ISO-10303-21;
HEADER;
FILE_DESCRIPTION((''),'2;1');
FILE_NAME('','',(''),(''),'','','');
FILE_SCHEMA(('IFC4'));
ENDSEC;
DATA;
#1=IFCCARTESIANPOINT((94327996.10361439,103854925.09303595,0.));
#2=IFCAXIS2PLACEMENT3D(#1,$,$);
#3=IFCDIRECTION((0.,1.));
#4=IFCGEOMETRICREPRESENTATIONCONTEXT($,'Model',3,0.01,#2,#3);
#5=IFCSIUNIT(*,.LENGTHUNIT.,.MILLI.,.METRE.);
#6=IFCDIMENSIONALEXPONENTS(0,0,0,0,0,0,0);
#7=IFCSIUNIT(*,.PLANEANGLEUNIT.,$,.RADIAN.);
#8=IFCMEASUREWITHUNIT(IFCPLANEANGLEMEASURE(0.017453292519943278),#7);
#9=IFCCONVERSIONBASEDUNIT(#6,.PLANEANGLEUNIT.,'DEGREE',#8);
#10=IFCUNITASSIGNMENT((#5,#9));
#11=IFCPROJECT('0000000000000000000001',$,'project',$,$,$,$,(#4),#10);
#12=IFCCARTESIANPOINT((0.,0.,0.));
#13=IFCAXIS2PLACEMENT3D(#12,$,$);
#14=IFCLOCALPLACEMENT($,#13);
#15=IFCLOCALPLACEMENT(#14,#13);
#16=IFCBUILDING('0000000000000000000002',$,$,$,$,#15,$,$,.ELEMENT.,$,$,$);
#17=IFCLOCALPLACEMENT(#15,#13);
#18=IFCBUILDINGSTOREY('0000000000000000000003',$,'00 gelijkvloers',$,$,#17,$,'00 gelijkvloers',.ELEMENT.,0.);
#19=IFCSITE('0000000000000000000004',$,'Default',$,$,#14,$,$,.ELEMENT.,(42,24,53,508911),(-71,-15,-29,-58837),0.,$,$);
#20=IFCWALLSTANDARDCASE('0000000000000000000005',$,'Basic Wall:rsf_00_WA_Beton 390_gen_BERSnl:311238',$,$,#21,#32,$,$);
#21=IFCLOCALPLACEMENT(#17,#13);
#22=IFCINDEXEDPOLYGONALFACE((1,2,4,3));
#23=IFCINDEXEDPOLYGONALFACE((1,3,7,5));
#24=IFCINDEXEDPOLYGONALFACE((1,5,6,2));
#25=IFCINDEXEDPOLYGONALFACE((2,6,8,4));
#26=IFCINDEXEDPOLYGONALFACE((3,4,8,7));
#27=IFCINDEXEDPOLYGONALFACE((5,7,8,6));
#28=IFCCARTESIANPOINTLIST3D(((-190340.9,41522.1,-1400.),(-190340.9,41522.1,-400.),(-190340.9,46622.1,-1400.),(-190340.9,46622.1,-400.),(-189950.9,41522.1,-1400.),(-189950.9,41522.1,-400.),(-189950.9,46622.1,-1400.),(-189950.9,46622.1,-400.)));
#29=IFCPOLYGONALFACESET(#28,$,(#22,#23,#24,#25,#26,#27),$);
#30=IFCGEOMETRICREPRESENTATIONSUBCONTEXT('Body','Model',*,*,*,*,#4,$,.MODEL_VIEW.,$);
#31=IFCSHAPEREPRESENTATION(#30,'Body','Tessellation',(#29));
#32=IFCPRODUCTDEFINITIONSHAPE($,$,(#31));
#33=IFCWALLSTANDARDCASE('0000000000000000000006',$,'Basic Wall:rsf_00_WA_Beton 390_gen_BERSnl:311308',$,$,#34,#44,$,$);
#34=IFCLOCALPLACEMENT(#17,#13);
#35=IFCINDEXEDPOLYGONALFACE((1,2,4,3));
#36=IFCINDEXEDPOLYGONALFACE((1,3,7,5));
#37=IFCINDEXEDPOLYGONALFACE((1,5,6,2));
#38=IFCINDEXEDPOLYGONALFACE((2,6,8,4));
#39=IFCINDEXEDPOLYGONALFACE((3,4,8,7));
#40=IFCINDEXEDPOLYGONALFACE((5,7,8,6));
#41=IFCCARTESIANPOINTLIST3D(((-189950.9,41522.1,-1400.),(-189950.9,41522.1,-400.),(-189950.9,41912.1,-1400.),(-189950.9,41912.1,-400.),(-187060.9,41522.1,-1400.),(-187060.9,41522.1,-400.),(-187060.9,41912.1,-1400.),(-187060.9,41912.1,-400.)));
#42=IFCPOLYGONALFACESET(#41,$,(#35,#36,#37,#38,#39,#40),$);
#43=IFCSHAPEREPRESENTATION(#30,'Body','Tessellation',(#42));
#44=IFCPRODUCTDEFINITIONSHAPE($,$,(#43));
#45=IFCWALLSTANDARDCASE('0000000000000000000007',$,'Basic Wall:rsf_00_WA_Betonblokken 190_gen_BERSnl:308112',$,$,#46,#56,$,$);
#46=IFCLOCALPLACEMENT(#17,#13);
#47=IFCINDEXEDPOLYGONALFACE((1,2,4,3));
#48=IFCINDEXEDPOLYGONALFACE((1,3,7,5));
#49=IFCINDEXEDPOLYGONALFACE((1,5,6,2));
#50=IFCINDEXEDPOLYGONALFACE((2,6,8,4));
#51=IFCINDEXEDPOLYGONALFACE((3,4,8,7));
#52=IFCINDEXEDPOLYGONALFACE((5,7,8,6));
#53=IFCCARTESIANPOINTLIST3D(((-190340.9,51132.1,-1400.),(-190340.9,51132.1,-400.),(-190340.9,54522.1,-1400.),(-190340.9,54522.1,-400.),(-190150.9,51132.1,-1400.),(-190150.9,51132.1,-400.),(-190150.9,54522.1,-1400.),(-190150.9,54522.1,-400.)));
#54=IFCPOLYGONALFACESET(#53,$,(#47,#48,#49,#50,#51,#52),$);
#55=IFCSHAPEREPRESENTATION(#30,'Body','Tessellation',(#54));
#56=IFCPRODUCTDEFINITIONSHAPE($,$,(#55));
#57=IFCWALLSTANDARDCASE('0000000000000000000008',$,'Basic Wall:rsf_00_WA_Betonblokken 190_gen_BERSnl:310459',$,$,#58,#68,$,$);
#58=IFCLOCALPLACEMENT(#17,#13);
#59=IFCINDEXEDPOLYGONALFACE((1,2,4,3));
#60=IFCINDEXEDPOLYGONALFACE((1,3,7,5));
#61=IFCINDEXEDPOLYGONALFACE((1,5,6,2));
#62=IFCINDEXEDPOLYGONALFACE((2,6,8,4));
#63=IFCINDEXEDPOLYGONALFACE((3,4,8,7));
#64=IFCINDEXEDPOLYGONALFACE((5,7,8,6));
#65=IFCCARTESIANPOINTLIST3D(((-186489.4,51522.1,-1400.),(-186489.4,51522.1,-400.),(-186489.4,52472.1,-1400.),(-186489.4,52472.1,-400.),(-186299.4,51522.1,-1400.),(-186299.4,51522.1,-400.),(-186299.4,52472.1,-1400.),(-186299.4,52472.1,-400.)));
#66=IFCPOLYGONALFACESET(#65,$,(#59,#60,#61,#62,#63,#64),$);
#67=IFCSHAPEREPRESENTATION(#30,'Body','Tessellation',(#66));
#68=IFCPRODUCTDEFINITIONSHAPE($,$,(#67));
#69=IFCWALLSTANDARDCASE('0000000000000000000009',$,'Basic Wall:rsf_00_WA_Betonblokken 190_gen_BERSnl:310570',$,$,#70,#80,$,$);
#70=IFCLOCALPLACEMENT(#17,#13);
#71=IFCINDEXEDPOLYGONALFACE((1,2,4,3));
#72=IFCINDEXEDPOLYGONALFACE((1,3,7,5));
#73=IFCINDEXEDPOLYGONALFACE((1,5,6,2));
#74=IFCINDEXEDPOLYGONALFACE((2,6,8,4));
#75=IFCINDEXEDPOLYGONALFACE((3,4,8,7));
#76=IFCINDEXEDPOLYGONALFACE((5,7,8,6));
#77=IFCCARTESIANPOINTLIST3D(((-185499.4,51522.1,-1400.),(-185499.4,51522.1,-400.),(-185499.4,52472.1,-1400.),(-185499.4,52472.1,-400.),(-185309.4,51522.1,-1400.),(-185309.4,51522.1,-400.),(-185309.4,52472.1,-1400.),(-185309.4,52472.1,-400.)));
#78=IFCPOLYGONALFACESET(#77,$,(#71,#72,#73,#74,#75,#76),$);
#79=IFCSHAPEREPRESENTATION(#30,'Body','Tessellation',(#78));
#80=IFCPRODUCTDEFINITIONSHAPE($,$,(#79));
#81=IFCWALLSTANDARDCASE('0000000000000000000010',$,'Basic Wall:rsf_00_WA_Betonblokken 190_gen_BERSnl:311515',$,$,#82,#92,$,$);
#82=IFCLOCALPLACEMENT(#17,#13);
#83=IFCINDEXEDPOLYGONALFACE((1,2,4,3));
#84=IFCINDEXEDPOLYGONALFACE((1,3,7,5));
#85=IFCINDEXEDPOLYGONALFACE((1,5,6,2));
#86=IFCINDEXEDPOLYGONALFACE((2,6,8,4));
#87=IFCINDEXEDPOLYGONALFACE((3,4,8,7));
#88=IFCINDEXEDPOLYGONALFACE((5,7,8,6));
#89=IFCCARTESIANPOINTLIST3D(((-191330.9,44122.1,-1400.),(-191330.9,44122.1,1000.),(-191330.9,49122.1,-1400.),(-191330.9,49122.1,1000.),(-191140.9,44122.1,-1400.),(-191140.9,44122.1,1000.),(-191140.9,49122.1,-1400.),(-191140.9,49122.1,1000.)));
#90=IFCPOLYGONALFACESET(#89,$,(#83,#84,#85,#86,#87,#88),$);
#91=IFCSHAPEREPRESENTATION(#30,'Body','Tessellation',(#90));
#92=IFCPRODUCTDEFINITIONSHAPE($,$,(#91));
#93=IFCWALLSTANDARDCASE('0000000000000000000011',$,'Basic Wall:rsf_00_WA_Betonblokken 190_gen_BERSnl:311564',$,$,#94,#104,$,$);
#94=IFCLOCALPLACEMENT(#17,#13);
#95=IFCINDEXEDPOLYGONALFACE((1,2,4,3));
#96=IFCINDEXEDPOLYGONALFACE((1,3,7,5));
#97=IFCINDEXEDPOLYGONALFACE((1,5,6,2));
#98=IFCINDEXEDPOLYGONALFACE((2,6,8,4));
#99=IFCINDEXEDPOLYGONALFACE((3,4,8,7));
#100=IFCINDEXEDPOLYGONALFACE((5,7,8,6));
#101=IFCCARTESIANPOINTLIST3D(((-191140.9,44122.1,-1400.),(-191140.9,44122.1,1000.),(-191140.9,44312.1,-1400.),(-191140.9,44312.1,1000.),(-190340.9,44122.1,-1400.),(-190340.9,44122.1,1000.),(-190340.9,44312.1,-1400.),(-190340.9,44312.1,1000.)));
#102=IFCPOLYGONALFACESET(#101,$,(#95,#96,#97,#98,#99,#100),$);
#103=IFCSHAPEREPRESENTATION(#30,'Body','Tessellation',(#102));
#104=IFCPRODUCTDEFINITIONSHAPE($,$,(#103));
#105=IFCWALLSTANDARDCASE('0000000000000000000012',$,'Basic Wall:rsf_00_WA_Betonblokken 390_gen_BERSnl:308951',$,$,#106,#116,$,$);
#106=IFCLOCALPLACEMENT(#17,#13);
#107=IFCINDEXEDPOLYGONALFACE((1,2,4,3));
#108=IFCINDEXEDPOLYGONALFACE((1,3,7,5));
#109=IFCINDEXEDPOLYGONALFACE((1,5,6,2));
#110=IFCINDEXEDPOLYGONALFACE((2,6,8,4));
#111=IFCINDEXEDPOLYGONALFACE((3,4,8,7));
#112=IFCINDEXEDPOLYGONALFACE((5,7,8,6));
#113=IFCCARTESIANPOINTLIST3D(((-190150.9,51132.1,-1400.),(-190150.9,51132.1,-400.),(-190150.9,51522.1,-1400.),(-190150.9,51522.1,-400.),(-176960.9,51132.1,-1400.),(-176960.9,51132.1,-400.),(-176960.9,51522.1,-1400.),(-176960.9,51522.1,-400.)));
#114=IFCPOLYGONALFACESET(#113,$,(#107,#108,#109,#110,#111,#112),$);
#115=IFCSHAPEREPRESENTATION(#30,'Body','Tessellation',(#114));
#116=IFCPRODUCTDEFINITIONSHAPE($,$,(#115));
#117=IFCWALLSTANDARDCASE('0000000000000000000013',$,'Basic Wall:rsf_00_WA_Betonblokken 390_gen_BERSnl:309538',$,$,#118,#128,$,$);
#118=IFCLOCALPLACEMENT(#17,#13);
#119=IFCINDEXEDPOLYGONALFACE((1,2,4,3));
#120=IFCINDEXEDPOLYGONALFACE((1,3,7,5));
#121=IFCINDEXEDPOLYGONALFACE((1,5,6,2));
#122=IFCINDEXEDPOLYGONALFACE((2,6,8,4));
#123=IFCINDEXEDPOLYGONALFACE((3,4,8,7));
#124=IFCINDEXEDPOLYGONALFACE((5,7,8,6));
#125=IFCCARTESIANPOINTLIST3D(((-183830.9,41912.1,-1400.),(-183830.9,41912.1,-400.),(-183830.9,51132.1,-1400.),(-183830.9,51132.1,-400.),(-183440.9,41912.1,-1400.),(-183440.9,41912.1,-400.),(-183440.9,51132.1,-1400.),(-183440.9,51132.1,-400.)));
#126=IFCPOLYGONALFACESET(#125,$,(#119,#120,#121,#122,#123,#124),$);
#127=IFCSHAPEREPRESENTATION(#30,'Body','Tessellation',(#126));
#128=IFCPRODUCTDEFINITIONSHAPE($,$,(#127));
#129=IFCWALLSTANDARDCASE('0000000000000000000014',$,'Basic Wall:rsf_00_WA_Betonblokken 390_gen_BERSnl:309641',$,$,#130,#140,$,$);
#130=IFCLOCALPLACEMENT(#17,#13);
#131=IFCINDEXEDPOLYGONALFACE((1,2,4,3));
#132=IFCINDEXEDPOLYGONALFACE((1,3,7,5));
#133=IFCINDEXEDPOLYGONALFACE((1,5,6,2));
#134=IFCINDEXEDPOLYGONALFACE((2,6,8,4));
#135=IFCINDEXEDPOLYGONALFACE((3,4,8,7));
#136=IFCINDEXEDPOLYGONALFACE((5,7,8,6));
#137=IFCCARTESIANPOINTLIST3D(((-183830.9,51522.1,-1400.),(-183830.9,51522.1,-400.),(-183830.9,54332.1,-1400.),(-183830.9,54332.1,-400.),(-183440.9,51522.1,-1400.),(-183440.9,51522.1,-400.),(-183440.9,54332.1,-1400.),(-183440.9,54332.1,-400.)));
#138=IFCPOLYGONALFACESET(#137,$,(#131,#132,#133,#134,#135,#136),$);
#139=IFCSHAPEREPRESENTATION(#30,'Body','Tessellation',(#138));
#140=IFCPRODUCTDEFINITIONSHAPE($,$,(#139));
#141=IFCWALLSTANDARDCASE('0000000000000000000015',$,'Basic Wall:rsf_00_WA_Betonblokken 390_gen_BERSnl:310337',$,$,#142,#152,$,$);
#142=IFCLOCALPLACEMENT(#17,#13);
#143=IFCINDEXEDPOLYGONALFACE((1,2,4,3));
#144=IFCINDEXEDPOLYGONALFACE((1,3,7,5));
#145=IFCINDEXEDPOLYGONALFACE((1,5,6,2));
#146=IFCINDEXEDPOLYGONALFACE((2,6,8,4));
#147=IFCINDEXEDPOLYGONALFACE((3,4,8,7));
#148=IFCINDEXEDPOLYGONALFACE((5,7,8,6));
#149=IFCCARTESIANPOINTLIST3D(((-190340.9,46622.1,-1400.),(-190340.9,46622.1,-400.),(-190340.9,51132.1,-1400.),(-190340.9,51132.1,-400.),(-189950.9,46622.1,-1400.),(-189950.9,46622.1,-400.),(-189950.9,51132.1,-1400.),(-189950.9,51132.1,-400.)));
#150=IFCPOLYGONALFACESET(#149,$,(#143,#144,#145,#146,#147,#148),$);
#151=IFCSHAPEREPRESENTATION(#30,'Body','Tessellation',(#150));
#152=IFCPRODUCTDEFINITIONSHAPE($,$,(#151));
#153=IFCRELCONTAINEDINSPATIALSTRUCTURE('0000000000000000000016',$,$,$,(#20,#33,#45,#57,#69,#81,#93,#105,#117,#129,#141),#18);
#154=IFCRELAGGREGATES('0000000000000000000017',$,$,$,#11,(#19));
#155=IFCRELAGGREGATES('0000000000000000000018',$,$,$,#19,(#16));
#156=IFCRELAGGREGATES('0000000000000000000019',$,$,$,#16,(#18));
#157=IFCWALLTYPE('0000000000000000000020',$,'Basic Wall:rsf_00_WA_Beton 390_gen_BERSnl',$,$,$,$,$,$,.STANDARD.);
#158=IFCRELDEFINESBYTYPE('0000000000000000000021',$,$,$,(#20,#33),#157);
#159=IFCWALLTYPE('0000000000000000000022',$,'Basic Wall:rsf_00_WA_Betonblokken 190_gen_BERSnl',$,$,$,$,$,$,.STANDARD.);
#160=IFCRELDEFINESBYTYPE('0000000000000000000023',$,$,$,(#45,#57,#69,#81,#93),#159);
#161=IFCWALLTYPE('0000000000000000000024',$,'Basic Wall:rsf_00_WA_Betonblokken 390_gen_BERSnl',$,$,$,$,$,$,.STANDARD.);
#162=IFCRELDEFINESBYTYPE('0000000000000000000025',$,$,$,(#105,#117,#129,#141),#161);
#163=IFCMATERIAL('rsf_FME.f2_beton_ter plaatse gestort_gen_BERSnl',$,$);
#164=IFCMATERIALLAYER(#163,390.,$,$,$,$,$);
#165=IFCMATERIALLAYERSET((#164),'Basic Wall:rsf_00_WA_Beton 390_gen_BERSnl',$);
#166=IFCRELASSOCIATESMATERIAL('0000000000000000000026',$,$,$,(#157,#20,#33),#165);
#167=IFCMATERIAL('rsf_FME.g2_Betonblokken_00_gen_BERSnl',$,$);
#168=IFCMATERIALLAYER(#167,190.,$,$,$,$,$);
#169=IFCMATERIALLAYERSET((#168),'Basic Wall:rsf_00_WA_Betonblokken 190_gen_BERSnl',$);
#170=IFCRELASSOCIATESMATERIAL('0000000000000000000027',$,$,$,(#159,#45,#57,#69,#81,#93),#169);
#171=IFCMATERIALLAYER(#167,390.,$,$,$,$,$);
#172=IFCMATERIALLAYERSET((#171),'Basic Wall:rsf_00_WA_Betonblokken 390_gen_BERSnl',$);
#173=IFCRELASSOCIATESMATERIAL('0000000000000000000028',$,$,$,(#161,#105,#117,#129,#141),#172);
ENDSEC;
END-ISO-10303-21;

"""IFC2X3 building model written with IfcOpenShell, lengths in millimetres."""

from ifc_helpers import new_model, entity, si_unit, converted_unit, direction, frame, frame_2d, origin, place, context, subcontext, project, spatial, rectangle, extrude, material, layer, layer_set, layer_usage, type_object, element, save


model = new_model("IFC2X3")

# Units and contexts
model_context = context("Model", 3, precision=0.01, world=frame((94327996.10361439, 103854925.09303595, 0.0)), true_north=direction((0.0, 1.0)))
body_context = subcontext(model_context, "Body", "Model", "MODEL_VIEW")
ifc_project = project(units=[si_unit("LENGTHUNIT", "METRE", prefix="MILLI"), converted_unit("PLANEANGLEUNIT", "DEGREE", entity("IfcPlaneAngleMeasure", 0.017453292519943278), si_unit("PLANEANGLEUNIT", "RADIAN"), dimensions=[0, 0, 0, 0, 0, 0, 0])], contexts=[model_context])

# Site, building, storey
site_placement = place(None, origin())
site = spatial("IfcSite", under=ifc_project, at=site_placement, Name="Default", CompositionType="ELEMENT", RefLatitude=(42, 24, 53, 508911), RefLongitude=(-71, -15, -29, -58837), RefElevation=0.0)
building_placement = place(site_placement, origin())
building = spatial("IfcBuilding", under=site, at=building_placement, CompositionType="ELEMENT")
storey_placement = place(building_placement, origin())
storey = spatial("IfcBuildingStorey", under=building, at=storey_placement, Name="00 gelijkvloers", LongName="00 gelijkvloers", CompositionType="ELEMENT", Elevation=0.0)

# Walls
ifc_material_1 = material(Name="rsf_FME.f2_beton_ter plaatse gestort_gen_BERSnl")
ifc_layer_1 = layer(ifc_material_1, 390.0)
ifc_layer_set_1 = layer_set([ifc_layer_1], Name="Basic Wall:rsf_00_WA_Beton 390_gen_BERSnl")
ifc_layer_usage_1 = layer_usage(ifc_layer_set_1, "AXIS2", "POSITIVE", -195.0)
wall_type_1 = type_object("IfcWallType", Name="Basic Wall:rsf_00_WA_Beton 390_gen_BERSnl", PredefinedType="STANDARD", material=ifc_layer_set_1)
wall_1_placement = place(storey_placement, frame((-190145.9, 46622.1, -1400.0), z_axis=(0.0, 0.0, 1.0), x_axis=(0.0, -1.0, 0.0)))
element("IfcWallStandardCase", 1, at=wall_1_placement, inside=storey, type_object=wall_type_1, material=ifc_layer_usage_1, Name="Basic Wall:rsf_00_WA_Beton 390_gen_BERSnl:311238", context=body_context, shape_type="SweptSolid", body=[
    extrude(rectangle(XDim=5100.0, YDim=390.0, at=frame_2d((2550.0, 0.0), x_axis=(-1.0, 0.0))), origin(), (0.0, 0.0, 1.0), 1000.0),
])
ifc_layer_usage_2 = layer_usage(ifc_layer_set_1, "AXIS2", "POSITIVE", -195.0)
wall_2_placement = place(storey_placement, frame((-189950.9, 41717.1, -1400.0)))
element("IfcWallStandardCase", 2, at=wall_2_placement, inside=storey, type_object=wall_type_1, material=ifc_layer_usage_2, Name="Basic Wall:rsf_00_WA_Beton 390_gen_BERSnl:311308", context=body_context, shape_type="SweptSolid", body=[
    extrude(rectangle(XDim=2890.0, YDim=390.0, at=frame_2d((1445.0, 0.0), x_axis=(-1.0, 0.0))), origin(), (0.0, 0.0, 1.0), 1000.0),
])
ifc_material_2 = material(Name="rsf_FME.g2_Betonblokken_00_gen_BERSnl")
ifc_layer_2 = layer(ifc_material_2, 190.0)
ifc_layer_set_2 = layer_set([ifc_layer_2], Name="Basic Wall:rsf_00_WA_Betonblokken 190_gen_BERSnl")
ifc_layer_usage_3 = layer_usage(ifc_layer_set_2, "AXIS2", "NEGATIVE", 95.0)
wall_type_2 = type_object("IfcWallType", Name="Basic Wall:rsf_00_WA_Betonblokken 190_gen_BERSnl", PredefinedType="STANDARD", material=ifc_layer_set_2)
wall_3_placement = place(storey_placement, frame((-190245.9, 51132.1, -1400.0), z_axis=(0.0, 0.0, 1.0), x_axis=(0.0, 1.0, 0.0)))
element("IfcWallStandardCase", 3, at=wall_3_placement, inside=storey, type_object=wall_type_2, material=ifc_layer_usage_3, Name="Basic Wall:rsf_00_WA_Betonblokken 190_gen_BERSnl:308112", context=body_context, shape_type="SweptSolid", body=[
    extrude(rectangle(XDim=3390.0, YDim=190.0, at=frame_2d((1695.0, 0.0), x_axis=(-1.0, 0.0))), origin(), (0.0, 0.0, 1.0), 1000.0),
])
ifc_layer_usage_4 = layer_usage(ifc_layer_set_2, "AXIS2", "POSITIVE", -95.0)
wall_4_placement = place(storey_placement, frame((-186394.4, 51522.1, -1400.0), z_axis=(0.0, 0.0, 1.0), x_axis=(0.0, 1.0, 0.0)))
element("IfcWallStandardCase", 4, at=wall_4_placement, inside=storey, type_object=wall_type_2, material=ifc_layer_usage_4, Name="Basic Wall:rsf_00_WA_Betonblokken 190_gen_BERSnl:310459", context=body_context, shape_type="SweptSolid", body=[
    extrude(rectangle(XDim=950.0, YDim=190.0, at=frame_2d((475.0, 0.0), x_axis=(-1.0, 0.0))), origin(), (0.0, 0.0, 1.0), 1000.0),
])
ifc_layer_usage_5 = layer_usage(ifc_layer_set_2, "AXIS2", "NEGATIVE", 95.0)
wall_5_placement = place(storey_placement, frame((-185404.4, 51522.1, -1400.0), z_axis=(0.0, 0.0, 1.0), x_axis=(0.0, 1.0, 0.0)))
element("IfcWallStandardCase", 5, at=wall_5_placement, inside=storey, type_object=wall_type_2, material=ifc_layer_usage_5, Name="Basic Wall:rsf_00_WA_Betonblokken 190_gen_BERSnl:310570", context=body_context, shape_type="SweptSolid", body=[
    extrude(rectangle(XDim=950.0, YDim=190.0, at=frame_2d((475.0, 0.0), x_axis=(-1.0, 0.0))), origin(), (0.0, 0.0, 1.0), 1000.0),
])
ifc_layer_usage_6 = layer_usage(ifc_layer_set_2, "AXIS2", "NEGATIVE", 95.0)
wall_6_placement = place(storey_placement, frame((-191235.9, 49122.1, -1400.0), z_axis=(0.0, 0.0, 1.0), x_axis=(0.0, -1.0, 0.0)))
element("IfcWallStandardCase", 6, at=wall_6_placement, inside=storey, type_object=wall_type_2, material=ifc_layer_usage_6, Name="Basic Wall:rsf_00_WA_Betonblokken 190_gen_BERSnl:311515", context=body_context, shape_type="SweptSolid", body=[
    extrude(rectangle(XDim=5000.0, YDim=190.0, at=frame_2d((2500.0, 0.0), x_axis=(-1.0, 0.0))), origin(), (0.0, 0.0, 1.0), 2400.0),
])
ifc_layer_usage_7 = layer_usage(ifc_layer_set_2, "AXIS2", "NEGATIVE", 95.0)
wall_7_placement = place(storey_placement, frame((-191140.9, 44217.1, -1400.0)))
element("IfcWallStandardCase", 7, at=wall_7_placement, inside=storey, type_object=wall_type_2, material=ifc_layer_usage_7, Name="Basic Wall:rsf_00_WA_Betonblokken 190_gen_BERSnl:311564", context=body_context, shape_type="SweptSolid", body=[
    extrude(rectangle(XDim=800.0, YDim=190.0, at=frame_2d((400.0, 0.0), x_axis=(-1.0, 0.0))), origin(), (0.0, 0.0, 1.0), 2400.0),
])
ifc_layer_3 = layer(ifc_material_2, 390.0)
ifc_layer_set_3 = layer_set([ifc_layer_3], Name="Basic Wall:rsf_00_WA_Betonblokken 390_gen_BERSnl")
ifc_layer_usage_8 = layer_usage(ifc_layer_set_3, "AXIS2", "NEGATIVE", 195.0)
wall_type_3 = type_object("IfcWallType", Name="Basic Wall:rsf_00_WA_Betonblokken 390_gen_BERSnl", PredefinedType="STANDARD", material=ifc_layer_set_3)
wall_8_placement = place(storey_placement, frame((-190150.9, 51327.1, -1400.0)))
element("IfcWallStandardCase", 8, at=wall_8_placement, inside=storey, type_object=wall_type_3, material=ifc_layer_usage_8, Name="Basic Wall:rsf_00_WA_Betonblokken 390_gen_BERSnl:308951", context=body_context, shape_type="SweptSolid", body=[
    extrude(rectangle(XDim=13190.0, YDim=390.0, at=frame_2d((6595.0, 0.0), x_axis=(-1.0, 0.0))), origin(), (0.0, 0.0, 1.0), 1000.0),
])
ifc_layer_usage_9 = layer_usage(ifc_layer_set_3, "AXIS2", "NEGATIVE", 195.0)
wall_9_placement = place(storey_placement, frame((-183635.9, 41912.1, -1400.0), z_axis=(0.0, 0.0, 1.0), x_axis=(0.0, 1.0, 0.0)))
element("IfcWallStandardCase", 9, at=wall_9_placement, inside=storey, type_object=wall_type_3, material=ifc_layer_usage_9, Name="Basic Wall:rsf_00_WA_Betonblokken 390_gen_BERSnl:309538", context=body_context, shape_type="SweptSolid", body=[
    extrude(rectangle(XDim=9220.0, YDim=390.0, at=frame_2d((4610.0, 0.0), x_axis=(-1.0, 0.0))), origin(), (0.0, 0.0, 1.0), 1000.0),
])
ifc_layer_usage_10 = layer_usage(ifc_layer_set_3, "AXIS2", "POSITIVE", -195.0)
wall_10_placement = place(storey_placement, frame((-183635.9, 51522.1, -1400.0), z_axis=(0.0, 0.0, 1.0), x_axis=(0.0, 1.0, 0.0)))
element("IfcWallStandardCase", 10, at=wall_10_placement, inside=storey, type_object=wall_type_3, material=ifc_layer_usage_10, Name="Basic Wall:rsf_00_WA_Betonblokken 390_gen_BERSnl:309641", context=body_context, shape_type="SweptSolid", body=[
    extrude(rectangle(XDim=2810.0, YDim=390.0, at=frame_2d((1405.0, 0.0), x_axis=(-1.0, 0.0))), origin(), (0.0, 0.0, 1.0), 1000.0),
])
ifc_layer_usage_11 = layer_usage(ifc_layer_set_3, "AXIS2", "NEGATIVE", 195.0)
wall_11_placement = place(storey_placement, frame((-190145.9, 51132.1, -1400.0), z_axis=(0.0, 0.0, 1.0), x_axis=(0.0, -1.0, 0.0)))
element("IfcWallStandardCase", 11, at=wall_11_placement, inside=storey, type_object=wall_type_3, material=ifc_layer_usage_11, Name="Basic Wall:rsf_00_WA_Betonblokken 390_gen_BERSnl:310337", context=body_context, shape_type="SweptSolid", body=[
    extrude(rectangle(XDim=4510.0, YDim=390.0, at=frame_2d((2255.0, 0.0), x_axis=(-1.0, 0.0))), origin(), (0.0, 0.0, 1.0), 1000.0),
])

save(model, "model.ifc")
